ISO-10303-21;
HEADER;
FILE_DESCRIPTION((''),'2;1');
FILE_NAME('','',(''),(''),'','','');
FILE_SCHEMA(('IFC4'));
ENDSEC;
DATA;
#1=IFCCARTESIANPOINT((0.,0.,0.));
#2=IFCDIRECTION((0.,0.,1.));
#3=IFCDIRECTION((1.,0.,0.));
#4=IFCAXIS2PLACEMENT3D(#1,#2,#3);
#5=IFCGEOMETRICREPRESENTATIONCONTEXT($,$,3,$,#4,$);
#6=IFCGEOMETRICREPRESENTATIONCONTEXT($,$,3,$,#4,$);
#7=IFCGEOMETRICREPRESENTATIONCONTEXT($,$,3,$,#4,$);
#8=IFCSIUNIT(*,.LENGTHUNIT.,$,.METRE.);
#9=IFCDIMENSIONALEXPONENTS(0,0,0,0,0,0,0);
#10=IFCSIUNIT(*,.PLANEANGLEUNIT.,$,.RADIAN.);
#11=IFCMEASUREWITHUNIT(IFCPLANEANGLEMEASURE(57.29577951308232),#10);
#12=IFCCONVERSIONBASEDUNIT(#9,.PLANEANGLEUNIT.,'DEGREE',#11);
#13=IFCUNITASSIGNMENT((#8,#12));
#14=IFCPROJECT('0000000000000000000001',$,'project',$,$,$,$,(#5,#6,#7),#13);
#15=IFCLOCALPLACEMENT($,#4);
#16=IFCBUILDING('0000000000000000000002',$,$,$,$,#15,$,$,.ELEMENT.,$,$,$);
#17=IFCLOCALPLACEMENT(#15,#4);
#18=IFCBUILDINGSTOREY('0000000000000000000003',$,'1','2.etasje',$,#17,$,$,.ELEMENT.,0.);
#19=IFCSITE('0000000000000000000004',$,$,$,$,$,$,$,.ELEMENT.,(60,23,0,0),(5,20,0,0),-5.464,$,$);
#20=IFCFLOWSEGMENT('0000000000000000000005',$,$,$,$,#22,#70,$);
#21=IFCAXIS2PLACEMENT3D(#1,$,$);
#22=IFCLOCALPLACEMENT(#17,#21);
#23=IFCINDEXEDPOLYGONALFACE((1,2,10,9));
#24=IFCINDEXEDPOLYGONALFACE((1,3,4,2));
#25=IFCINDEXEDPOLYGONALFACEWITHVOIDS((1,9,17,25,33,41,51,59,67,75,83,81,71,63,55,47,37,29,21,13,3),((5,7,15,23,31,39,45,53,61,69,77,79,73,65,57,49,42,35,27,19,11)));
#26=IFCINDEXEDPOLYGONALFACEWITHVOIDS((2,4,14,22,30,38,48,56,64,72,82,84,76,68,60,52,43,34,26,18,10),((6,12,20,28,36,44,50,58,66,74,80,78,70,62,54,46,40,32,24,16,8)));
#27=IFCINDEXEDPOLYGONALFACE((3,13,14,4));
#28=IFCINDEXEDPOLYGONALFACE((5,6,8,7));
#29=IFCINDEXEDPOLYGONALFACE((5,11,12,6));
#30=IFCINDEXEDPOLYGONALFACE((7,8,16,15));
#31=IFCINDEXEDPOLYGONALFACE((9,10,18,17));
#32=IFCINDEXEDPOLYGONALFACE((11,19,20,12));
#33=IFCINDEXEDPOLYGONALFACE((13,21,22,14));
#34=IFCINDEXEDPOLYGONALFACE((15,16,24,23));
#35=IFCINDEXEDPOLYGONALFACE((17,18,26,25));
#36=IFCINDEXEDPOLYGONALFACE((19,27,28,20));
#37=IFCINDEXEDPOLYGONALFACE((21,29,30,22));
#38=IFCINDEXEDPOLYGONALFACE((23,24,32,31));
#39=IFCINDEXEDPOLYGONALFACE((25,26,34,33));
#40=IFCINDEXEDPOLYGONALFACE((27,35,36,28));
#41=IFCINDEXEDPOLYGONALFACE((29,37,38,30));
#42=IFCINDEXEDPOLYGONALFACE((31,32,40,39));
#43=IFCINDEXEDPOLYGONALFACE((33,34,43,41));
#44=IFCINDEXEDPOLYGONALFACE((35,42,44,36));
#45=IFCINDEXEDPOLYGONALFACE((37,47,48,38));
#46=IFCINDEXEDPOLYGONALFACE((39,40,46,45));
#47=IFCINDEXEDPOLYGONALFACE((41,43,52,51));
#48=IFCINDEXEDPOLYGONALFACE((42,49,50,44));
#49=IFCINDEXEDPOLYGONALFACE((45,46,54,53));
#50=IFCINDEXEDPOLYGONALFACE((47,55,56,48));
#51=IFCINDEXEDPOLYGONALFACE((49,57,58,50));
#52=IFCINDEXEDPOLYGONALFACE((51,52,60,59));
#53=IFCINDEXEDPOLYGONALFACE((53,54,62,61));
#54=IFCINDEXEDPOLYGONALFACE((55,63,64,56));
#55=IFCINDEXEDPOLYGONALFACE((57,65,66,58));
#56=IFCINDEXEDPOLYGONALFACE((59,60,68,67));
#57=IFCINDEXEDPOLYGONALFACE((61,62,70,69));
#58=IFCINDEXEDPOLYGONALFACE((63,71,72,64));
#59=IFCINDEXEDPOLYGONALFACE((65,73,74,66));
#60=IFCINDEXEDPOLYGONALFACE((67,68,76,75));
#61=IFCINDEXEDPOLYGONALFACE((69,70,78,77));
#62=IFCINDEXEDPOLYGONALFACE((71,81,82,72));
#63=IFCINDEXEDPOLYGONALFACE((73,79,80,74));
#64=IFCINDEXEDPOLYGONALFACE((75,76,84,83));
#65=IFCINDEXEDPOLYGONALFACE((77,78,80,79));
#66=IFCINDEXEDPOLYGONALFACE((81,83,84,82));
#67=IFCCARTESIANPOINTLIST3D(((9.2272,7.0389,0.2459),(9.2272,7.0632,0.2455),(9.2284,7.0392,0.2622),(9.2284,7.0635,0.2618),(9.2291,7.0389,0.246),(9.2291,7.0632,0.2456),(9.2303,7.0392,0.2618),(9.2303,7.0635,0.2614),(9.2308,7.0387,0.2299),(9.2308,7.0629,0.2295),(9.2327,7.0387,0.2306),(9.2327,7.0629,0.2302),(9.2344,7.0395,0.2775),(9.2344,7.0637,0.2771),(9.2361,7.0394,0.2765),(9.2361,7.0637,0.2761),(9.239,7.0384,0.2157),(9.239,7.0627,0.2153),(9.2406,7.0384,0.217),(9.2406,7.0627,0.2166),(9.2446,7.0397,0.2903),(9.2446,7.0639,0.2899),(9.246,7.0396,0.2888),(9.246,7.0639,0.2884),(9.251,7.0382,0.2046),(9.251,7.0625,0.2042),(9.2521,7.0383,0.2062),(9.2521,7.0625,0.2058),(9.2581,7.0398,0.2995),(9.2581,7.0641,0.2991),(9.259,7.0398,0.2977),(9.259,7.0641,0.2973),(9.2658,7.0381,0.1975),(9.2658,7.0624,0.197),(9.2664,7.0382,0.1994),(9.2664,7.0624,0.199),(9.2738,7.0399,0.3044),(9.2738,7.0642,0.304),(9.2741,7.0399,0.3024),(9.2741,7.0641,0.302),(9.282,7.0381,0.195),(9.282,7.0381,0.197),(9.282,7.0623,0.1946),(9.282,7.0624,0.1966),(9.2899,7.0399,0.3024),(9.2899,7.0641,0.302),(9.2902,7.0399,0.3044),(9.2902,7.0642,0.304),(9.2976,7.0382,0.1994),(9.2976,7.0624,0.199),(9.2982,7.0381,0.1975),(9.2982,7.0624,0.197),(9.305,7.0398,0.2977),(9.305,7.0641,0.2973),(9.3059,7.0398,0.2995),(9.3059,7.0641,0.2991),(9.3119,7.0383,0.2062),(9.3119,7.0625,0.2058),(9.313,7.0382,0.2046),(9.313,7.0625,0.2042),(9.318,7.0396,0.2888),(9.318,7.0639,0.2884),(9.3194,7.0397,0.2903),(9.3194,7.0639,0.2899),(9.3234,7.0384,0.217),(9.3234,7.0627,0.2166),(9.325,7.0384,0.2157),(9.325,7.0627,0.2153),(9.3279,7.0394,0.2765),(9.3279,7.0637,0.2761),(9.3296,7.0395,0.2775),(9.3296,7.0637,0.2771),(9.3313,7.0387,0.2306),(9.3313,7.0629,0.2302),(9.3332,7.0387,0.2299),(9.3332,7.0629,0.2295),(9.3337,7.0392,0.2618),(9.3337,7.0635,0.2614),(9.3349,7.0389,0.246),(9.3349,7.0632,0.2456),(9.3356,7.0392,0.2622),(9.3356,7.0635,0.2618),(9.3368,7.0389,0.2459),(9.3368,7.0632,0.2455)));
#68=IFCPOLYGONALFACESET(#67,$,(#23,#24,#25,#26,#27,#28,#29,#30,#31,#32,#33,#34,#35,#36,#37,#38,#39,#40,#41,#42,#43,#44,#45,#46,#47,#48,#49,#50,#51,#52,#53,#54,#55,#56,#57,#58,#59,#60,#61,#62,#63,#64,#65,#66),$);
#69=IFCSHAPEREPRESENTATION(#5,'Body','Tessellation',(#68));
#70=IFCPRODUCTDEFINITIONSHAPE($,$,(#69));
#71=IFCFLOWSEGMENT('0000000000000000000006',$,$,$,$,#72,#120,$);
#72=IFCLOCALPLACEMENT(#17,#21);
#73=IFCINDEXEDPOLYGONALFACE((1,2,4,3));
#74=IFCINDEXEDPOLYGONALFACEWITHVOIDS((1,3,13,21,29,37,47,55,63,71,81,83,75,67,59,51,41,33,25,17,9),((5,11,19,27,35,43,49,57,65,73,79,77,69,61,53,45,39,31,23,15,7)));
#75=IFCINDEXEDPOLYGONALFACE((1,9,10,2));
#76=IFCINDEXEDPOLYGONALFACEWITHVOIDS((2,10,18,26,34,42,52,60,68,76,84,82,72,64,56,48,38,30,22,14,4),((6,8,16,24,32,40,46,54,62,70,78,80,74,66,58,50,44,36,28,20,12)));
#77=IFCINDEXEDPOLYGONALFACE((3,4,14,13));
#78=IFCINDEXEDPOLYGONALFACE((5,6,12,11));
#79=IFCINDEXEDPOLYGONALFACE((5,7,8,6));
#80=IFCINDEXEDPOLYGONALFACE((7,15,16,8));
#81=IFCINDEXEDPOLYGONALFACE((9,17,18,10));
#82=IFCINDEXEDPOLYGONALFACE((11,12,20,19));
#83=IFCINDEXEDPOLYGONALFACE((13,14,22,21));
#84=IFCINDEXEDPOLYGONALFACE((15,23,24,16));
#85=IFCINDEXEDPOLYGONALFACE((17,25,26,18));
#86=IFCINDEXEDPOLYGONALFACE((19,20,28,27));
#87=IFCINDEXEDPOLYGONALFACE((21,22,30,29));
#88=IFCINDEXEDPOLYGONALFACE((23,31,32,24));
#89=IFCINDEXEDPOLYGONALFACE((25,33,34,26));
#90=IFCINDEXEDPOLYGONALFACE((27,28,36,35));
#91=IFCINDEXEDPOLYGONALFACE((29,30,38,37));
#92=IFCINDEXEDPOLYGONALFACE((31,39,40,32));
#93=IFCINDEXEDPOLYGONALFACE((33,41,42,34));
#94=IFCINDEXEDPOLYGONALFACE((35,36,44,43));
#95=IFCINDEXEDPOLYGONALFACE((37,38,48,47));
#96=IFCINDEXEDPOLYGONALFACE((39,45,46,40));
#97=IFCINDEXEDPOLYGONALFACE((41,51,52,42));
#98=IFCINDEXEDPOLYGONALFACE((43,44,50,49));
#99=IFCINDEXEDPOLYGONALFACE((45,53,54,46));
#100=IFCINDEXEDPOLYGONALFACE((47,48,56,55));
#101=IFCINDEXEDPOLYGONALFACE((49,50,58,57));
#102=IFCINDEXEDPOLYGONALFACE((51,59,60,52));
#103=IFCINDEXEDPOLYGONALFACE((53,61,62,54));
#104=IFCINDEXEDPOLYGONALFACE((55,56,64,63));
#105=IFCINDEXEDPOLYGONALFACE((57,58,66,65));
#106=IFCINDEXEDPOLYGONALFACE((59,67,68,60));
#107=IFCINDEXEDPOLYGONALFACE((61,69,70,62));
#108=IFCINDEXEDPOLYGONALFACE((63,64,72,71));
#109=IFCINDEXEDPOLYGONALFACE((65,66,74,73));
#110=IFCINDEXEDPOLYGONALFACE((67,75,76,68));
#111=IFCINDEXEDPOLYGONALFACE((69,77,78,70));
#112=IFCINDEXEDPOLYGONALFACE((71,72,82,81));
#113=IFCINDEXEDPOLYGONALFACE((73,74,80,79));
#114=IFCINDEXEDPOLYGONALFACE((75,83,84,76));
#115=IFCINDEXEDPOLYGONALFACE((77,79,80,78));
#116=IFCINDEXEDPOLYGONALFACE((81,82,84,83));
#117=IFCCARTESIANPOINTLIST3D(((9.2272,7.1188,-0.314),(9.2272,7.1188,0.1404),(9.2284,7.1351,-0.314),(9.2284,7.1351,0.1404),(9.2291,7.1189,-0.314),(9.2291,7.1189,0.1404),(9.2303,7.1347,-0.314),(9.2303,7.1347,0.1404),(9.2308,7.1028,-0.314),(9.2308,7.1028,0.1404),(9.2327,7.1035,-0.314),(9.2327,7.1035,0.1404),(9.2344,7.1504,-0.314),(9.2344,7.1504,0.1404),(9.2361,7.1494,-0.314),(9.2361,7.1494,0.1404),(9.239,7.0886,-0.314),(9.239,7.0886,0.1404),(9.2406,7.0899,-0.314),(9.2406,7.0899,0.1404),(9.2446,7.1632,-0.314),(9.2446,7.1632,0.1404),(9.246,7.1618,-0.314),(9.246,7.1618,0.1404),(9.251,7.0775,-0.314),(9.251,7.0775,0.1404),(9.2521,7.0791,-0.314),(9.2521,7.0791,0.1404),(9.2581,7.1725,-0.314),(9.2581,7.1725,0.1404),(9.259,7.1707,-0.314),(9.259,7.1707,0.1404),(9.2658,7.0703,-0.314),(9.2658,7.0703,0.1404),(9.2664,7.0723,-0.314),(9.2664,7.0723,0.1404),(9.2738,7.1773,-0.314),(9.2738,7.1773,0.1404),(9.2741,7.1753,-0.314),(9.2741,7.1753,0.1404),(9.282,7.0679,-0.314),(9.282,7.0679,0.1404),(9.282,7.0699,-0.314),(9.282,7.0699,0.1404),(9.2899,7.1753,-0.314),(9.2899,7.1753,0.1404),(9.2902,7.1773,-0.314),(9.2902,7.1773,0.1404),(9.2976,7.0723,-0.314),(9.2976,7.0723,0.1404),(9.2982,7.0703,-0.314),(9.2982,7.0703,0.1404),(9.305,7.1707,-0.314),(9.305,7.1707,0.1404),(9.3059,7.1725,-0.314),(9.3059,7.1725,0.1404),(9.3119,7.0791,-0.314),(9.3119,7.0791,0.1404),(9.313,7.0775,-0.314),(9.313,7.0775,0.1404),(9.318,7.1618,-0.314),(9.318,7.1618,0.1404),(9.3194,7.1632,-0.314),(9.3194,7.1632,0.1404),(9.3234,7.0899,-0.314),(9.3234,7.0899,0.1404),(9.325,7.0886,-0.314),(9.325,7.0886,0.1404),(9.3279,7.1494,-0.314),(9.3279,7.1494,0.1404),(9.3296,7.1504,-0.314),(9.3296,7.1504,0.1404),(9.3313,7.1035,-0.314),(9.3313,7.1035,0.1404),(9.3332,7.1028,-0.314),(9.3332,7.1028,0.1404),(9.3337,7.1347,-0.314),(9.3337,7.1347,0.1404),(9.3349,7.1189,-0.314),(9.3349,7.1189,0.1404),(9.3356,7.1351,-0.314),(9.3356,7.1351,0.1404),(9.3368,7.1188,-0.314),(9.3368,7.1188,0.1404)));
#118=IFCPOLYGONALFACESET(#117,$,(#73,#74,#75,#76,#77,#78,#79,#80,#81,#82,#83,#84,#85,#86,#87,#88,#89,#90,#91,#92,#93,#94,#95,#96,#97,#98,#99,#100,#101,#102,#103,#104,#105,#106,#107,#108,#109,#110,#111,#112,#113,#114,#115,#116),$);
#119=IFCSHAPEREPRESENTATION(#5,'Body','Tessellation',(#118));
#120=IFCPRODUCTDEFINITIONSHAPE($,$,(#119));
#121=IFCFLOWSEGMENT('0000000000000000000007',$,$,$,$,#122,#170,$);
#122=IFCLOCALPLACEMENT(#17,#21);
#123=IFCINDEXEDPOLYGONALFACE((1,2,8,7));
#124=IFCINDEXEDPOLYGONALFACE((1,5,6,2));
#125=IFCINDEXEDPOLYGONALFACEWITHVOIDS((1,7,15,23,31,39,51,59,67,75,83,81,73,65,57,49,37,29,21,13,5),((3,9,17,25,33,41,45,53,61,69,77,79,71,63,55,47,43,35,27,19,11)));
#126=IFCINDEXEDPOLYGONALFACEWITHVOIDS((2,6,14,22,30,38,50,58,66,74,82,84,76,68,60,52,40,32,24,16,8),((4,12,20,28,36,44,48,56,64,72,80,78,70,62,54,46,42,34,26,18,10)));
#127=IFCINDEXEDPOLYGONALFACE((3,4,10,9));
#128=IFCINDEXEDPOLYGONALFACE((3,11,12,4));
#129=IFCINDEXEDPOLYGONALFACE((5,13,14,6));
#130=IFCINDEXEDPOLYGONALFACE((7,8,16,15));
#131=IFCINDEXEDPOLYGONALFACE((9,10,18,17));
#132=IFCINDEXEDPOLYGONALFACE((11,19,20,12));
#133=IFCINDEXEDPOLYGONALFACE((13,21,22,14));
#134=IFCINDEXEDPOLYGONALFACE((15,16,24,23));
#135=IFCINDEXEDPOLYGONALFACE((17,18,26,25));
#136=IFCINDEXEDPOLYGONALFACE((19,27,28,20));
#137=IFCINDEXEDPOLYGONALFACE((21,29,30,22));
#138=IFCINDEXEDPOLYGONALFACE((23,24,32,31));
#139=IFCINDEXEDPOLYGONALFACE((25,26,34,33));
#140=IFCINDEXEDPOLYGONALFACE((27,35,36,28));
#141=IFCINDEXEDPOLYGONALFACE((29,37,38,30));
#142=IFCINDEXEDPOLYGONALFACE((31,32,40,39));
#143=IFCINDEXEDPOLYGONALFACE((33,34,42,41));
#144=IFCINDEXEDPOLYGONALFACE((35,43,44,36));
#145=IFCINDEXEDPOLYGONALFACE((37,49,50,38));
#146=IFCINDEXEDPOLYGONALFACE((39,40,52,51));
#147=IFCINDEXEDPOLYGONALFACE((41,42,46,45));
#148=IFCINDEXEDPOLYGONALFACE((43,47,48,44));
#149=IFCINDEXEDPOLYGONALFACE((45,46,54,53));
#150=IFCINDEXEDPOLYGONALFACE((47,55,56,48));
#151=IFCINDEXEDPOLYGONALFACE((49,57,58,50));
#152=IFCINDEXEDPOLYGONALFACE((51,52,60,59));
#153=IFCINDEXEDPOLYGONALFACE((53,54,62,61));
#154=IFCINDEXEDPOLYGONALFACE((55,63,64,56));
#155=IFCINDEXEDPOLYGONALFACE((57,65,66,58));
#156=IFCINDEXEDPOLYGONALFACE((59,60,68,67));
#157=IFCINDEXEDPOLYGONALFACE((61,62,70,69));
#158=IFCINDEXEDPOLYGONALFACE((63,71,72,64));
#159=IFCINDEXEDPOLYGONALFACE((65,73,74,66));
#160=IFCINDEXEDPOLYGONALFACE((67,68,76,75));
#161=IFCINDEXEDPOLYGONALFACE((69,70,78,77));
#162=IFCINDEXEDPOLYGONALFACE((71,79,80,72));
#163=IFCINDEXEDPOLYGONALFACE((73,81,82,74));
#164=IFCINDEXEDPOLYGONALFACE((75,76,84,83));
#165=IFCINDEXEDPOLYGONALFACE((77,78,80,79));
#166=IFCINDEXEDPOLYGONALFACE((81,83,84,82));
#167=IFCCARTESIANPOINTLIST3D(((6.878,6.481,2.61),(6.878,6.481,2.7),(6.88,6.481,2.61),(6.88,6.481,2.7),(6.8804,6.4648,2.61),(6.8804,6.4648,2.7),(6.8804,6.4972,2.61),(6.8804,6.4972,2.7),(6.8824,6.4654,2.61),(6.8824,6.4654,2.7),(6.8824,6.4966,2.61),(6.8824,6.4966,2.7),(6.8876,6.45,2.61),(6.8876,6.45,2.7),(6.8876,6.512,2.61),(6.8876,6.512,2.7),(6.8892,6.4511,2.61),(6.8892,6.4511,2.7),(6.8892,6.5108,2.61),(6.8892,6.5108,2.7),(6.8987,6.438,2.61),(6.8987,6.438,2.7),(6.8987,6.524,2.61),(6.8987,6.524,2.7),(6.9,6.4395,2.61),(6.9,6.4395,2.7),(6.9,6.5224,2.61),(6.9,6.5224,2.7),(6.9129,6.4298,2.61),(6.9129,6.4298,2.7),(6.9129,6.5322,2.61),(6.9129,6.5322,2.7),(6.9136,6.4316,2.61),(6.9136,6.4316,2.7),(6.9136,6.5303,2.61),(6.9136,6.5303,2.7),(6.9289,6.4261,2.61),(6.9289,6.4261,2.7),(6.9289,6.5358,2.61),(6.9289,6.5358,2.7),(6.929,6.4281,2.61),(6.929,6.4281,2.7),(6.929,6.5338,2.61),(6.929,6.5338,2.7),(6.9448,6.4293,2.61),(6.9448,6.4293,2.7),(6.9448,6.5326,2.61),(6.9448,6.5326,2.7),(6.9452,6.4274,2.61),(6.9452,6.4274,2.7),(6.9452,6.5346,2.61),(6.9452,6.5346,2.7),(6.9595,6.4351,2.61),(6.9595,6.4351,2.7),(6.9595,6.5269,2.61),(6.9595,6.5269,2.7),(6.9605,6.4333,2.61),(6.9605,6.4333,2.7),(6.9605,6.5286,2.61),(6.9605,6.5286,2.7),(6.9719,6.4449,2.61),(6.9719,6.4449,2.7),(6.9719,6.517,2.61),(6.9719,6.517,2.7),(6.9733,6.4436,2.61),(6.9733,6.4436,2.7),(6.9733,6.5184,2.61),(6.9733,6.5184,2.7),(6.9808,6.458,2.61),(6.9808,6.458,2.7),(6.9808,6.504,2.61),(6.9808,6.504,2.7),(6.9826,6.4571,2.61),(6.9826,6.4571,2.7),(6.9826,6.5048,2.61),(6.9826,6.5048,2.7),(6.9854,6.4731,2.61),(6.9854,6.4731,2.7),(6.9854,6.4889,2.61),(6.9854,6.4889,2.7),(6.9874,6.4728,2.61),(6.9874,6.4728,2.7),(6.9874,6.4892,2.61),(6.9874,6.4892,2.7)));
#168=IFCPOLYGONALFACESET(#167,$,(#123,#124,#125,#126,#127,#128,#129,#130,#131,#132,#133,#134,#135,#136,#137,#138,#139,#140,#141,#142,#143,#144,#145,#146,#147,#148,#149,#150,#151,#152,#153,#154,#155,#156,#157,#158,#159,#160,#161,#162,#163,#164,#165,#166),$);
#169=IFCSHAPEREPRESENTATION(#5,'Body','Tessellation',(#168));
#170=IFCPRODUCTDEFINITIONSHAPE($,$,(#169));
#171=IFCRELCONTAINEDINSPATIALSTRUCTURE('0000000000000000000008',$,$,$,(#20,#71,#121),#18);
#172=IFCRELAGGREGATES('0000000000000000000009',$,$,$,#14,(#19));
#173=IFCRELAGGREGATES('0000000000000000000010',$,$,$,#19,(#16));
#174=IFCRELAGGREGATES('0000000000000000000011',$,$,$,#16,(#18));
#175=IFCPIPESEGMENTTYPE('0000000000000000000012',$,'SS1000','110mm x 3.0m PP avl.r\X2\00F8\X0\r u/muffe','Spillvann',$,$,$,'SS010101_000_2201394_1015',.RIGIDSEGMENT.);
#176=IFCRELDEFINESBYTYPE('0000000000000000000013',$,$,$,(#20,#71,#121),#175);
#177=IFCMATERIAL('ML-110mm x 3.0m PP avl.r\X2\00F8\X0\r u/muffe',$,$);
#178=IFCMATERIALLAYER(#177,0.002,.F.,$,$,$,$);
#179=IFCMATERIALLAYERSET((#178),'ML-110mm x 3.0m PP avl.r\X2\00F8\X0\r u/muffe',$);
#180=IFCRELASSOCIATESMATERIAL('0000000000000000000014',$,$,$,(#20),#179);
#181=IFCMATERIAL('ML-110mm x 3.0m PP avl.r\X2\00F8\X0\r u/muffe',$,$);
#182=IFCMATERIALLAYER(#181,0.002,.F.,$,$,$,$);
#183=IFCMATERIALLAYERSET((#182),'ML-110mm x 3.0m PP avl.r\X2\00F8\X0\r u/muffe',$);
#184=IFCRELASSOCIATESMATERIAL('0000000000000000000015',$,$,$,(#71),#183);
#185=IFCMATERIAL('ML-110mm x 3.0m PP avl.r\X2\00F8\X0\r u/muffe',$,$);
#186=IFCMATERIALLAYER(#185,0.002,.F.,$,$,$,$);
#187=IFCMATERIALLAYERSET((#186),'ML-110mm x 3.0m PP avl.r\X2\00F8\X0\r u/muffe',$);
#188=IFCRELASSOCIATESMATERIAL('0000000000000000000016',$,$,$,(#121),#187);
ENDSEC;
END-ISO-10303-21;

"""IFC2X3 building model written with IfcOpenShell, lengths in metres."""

from ifc_helpers import new_model, entity, si_unit, converted_unit, frame, origin_with_axes, origin_2d_with_axis, place, context, project, spatial, hollow_circle, extrude, material, layer, layer_set, layer_usage, type_object, element, save


model = new_model("IFC2X3")

# Units and contexts
context_of_model_1 = context(None, 3, world=origin_with_axes())
context_of_model_2 = context(None, 3, world=origin_with_axes())
context_of_model_3 = context(None, 3, world=origin_with_axes())
ifc_project = project(units=[si_unit("LENGTHUNIT", "METRE"), converted_unit("PLANEANGLEUNIT", "DEGREE", entity("IfcPlaneAngleMeasure", 57.29577951308232), si_unit("PLANEANGLEUNIT", "RADIAN"), dimensions=[0, 0, 0, 0, 0, 0, 0])], contexts=[context_of_model_1, context_of_model_2, context_of_model_3])

# Site, building, storey
site = spatial("IfcSite", under=ifc_project, CompositionType="ELEMENT", RefLatitude=(60, 23, 0, 0), RefLongitude=(5, 20, 0, 0), RefElevation=-5.464)
building_placement = place(None, origin_with_axes())
building = spatial("IfcBuilding", under=site, at=building_placement, CompositionType="ELEMENT")
storey_placement = place(building_placement, origin_with_axes())
storey = spatial("IfcBuildingStorey", under=building, at=storey_placement, Name="1", Description="2.etasje", CompositionType="ELEMENT", Elevation=0.0)

# Flow segments
ifc_material_1 = material(Name="ML-110mm x 3.0m PP avl.rør u/muffe")
ifc_layer_1 = layer(ifc_material_1, 0.002, ventilated=False)
ifc_layer_set_1 = layer_set([ifc_layer_1], Name="ML-110mm x 3.0m PP avl.rør u/muffe")
ifc_layer_usage_1 = layer_usage(ifc_layer_set_1, "AXIS2", "POSITIVE", 0.0)
pipe_segment_type_1 = type_object("IfcPipeSegmentType", Name="SS1000", Description="110mm x 3.0m PP avl.rør u/muffe", ApplicableOccurrence="Spillvann", ElementType="SS010101_000_2201394_1015", PredefinedType="RIGIDSEGMENT")
flow_segment_1_placement = place(storey_placement, frame((9.282, 7.039, 0.25), z_axis=(0.0, 0.999861, -0.016664), x_axis=(0.0, -0.016664, -0.999861)))
element("IfcFlowSegment", 1, at=flow_segment_1_placement, inside=storey, type_object=pipe_segment_type_1, material=ifc_layer_usage_1, context=context_of_model_1, shape_type="SweptSolid", body=[
    extrude(hollow_circle(Radius=0.055, WallThickness=0.002, at=origin_2d_with_axis()), origin_with_axes(), (0.0, 0.0, 1.0), 0.0243),
])
ifc_material_2 = material(Name="ML-110mm x 3.0m PP avl.rør u/muffe")
ifc_layer_2 = layer(ifc_material_2, 0.002, ventilated=False)
ifc_layer_set_2 = layer_set([ifc_layer_2], Name="ML-110mm x 3.0m PP avl.rør u/muffe")
ifc_layer_usage_2 = layer_usage(ifc_layer_set_2, "AXIS2", "POSITIVE", 0.0)
flow_segment_2_placement = place(storey_placement, frame((9.282, 7.1229, 0.1404), z_axis=(0.0, 0.0, -1.0), x_axis=(0.0, -1.0, 0.0)))
element("IfcFlowSegment", 2, at=flow_segment_2_placement, inside=storey, type_object=pipe_segment_type_1, material=ifc_layer_usage_2, context=context_of_model_1, shape_type="SweptSolid", body=[
    extrude(hollow_circle(Radius=0.055, WallThickness=0.002, at=origin_2d_with_axis()), origin_with_axes(), (0.0, 0.0, 1.0), 0.4544),
])
ifc_material_3 = material(Name="ML-110mm x 3.0m PP avl.rør u/muffe")
ifc_layer_3 = layer(ifc_material_3, 0.002, ventilated=False)
ifc_layer_set_3 = layer_set([ifc_layer_3], Name="ML-110mm x 3.0m PP avl.rør u/muffe")
ifc_layer_usage_3 = layer_usage(ifc_layer_set_3, "AXIS2", "POSITIVE", 0.0)
flow_segment_3_placement = place(storey_placement, frame((6.933, 6.481, 2.7), z_axis=(0.0, 0.0, -1.0), x_axis=(-1.0, 0.0, 0.0)))
element("IfcFlowSegment", 3, at=flow_segment_3_placement, inside=storey, type_object=pipe_segment_type_1, material=ifc_layer_usage_3, context=context_of_model_1, shape_type="SweptSolid", body=[
    extrude(hollow_circle(Radius=0.055, WallThickness=0.002, at=origin_2d_with_axis()), origin_with_axes(), (0.0, 0.0, 1.0), 0.09),
])

save(model, "model.ifc")
